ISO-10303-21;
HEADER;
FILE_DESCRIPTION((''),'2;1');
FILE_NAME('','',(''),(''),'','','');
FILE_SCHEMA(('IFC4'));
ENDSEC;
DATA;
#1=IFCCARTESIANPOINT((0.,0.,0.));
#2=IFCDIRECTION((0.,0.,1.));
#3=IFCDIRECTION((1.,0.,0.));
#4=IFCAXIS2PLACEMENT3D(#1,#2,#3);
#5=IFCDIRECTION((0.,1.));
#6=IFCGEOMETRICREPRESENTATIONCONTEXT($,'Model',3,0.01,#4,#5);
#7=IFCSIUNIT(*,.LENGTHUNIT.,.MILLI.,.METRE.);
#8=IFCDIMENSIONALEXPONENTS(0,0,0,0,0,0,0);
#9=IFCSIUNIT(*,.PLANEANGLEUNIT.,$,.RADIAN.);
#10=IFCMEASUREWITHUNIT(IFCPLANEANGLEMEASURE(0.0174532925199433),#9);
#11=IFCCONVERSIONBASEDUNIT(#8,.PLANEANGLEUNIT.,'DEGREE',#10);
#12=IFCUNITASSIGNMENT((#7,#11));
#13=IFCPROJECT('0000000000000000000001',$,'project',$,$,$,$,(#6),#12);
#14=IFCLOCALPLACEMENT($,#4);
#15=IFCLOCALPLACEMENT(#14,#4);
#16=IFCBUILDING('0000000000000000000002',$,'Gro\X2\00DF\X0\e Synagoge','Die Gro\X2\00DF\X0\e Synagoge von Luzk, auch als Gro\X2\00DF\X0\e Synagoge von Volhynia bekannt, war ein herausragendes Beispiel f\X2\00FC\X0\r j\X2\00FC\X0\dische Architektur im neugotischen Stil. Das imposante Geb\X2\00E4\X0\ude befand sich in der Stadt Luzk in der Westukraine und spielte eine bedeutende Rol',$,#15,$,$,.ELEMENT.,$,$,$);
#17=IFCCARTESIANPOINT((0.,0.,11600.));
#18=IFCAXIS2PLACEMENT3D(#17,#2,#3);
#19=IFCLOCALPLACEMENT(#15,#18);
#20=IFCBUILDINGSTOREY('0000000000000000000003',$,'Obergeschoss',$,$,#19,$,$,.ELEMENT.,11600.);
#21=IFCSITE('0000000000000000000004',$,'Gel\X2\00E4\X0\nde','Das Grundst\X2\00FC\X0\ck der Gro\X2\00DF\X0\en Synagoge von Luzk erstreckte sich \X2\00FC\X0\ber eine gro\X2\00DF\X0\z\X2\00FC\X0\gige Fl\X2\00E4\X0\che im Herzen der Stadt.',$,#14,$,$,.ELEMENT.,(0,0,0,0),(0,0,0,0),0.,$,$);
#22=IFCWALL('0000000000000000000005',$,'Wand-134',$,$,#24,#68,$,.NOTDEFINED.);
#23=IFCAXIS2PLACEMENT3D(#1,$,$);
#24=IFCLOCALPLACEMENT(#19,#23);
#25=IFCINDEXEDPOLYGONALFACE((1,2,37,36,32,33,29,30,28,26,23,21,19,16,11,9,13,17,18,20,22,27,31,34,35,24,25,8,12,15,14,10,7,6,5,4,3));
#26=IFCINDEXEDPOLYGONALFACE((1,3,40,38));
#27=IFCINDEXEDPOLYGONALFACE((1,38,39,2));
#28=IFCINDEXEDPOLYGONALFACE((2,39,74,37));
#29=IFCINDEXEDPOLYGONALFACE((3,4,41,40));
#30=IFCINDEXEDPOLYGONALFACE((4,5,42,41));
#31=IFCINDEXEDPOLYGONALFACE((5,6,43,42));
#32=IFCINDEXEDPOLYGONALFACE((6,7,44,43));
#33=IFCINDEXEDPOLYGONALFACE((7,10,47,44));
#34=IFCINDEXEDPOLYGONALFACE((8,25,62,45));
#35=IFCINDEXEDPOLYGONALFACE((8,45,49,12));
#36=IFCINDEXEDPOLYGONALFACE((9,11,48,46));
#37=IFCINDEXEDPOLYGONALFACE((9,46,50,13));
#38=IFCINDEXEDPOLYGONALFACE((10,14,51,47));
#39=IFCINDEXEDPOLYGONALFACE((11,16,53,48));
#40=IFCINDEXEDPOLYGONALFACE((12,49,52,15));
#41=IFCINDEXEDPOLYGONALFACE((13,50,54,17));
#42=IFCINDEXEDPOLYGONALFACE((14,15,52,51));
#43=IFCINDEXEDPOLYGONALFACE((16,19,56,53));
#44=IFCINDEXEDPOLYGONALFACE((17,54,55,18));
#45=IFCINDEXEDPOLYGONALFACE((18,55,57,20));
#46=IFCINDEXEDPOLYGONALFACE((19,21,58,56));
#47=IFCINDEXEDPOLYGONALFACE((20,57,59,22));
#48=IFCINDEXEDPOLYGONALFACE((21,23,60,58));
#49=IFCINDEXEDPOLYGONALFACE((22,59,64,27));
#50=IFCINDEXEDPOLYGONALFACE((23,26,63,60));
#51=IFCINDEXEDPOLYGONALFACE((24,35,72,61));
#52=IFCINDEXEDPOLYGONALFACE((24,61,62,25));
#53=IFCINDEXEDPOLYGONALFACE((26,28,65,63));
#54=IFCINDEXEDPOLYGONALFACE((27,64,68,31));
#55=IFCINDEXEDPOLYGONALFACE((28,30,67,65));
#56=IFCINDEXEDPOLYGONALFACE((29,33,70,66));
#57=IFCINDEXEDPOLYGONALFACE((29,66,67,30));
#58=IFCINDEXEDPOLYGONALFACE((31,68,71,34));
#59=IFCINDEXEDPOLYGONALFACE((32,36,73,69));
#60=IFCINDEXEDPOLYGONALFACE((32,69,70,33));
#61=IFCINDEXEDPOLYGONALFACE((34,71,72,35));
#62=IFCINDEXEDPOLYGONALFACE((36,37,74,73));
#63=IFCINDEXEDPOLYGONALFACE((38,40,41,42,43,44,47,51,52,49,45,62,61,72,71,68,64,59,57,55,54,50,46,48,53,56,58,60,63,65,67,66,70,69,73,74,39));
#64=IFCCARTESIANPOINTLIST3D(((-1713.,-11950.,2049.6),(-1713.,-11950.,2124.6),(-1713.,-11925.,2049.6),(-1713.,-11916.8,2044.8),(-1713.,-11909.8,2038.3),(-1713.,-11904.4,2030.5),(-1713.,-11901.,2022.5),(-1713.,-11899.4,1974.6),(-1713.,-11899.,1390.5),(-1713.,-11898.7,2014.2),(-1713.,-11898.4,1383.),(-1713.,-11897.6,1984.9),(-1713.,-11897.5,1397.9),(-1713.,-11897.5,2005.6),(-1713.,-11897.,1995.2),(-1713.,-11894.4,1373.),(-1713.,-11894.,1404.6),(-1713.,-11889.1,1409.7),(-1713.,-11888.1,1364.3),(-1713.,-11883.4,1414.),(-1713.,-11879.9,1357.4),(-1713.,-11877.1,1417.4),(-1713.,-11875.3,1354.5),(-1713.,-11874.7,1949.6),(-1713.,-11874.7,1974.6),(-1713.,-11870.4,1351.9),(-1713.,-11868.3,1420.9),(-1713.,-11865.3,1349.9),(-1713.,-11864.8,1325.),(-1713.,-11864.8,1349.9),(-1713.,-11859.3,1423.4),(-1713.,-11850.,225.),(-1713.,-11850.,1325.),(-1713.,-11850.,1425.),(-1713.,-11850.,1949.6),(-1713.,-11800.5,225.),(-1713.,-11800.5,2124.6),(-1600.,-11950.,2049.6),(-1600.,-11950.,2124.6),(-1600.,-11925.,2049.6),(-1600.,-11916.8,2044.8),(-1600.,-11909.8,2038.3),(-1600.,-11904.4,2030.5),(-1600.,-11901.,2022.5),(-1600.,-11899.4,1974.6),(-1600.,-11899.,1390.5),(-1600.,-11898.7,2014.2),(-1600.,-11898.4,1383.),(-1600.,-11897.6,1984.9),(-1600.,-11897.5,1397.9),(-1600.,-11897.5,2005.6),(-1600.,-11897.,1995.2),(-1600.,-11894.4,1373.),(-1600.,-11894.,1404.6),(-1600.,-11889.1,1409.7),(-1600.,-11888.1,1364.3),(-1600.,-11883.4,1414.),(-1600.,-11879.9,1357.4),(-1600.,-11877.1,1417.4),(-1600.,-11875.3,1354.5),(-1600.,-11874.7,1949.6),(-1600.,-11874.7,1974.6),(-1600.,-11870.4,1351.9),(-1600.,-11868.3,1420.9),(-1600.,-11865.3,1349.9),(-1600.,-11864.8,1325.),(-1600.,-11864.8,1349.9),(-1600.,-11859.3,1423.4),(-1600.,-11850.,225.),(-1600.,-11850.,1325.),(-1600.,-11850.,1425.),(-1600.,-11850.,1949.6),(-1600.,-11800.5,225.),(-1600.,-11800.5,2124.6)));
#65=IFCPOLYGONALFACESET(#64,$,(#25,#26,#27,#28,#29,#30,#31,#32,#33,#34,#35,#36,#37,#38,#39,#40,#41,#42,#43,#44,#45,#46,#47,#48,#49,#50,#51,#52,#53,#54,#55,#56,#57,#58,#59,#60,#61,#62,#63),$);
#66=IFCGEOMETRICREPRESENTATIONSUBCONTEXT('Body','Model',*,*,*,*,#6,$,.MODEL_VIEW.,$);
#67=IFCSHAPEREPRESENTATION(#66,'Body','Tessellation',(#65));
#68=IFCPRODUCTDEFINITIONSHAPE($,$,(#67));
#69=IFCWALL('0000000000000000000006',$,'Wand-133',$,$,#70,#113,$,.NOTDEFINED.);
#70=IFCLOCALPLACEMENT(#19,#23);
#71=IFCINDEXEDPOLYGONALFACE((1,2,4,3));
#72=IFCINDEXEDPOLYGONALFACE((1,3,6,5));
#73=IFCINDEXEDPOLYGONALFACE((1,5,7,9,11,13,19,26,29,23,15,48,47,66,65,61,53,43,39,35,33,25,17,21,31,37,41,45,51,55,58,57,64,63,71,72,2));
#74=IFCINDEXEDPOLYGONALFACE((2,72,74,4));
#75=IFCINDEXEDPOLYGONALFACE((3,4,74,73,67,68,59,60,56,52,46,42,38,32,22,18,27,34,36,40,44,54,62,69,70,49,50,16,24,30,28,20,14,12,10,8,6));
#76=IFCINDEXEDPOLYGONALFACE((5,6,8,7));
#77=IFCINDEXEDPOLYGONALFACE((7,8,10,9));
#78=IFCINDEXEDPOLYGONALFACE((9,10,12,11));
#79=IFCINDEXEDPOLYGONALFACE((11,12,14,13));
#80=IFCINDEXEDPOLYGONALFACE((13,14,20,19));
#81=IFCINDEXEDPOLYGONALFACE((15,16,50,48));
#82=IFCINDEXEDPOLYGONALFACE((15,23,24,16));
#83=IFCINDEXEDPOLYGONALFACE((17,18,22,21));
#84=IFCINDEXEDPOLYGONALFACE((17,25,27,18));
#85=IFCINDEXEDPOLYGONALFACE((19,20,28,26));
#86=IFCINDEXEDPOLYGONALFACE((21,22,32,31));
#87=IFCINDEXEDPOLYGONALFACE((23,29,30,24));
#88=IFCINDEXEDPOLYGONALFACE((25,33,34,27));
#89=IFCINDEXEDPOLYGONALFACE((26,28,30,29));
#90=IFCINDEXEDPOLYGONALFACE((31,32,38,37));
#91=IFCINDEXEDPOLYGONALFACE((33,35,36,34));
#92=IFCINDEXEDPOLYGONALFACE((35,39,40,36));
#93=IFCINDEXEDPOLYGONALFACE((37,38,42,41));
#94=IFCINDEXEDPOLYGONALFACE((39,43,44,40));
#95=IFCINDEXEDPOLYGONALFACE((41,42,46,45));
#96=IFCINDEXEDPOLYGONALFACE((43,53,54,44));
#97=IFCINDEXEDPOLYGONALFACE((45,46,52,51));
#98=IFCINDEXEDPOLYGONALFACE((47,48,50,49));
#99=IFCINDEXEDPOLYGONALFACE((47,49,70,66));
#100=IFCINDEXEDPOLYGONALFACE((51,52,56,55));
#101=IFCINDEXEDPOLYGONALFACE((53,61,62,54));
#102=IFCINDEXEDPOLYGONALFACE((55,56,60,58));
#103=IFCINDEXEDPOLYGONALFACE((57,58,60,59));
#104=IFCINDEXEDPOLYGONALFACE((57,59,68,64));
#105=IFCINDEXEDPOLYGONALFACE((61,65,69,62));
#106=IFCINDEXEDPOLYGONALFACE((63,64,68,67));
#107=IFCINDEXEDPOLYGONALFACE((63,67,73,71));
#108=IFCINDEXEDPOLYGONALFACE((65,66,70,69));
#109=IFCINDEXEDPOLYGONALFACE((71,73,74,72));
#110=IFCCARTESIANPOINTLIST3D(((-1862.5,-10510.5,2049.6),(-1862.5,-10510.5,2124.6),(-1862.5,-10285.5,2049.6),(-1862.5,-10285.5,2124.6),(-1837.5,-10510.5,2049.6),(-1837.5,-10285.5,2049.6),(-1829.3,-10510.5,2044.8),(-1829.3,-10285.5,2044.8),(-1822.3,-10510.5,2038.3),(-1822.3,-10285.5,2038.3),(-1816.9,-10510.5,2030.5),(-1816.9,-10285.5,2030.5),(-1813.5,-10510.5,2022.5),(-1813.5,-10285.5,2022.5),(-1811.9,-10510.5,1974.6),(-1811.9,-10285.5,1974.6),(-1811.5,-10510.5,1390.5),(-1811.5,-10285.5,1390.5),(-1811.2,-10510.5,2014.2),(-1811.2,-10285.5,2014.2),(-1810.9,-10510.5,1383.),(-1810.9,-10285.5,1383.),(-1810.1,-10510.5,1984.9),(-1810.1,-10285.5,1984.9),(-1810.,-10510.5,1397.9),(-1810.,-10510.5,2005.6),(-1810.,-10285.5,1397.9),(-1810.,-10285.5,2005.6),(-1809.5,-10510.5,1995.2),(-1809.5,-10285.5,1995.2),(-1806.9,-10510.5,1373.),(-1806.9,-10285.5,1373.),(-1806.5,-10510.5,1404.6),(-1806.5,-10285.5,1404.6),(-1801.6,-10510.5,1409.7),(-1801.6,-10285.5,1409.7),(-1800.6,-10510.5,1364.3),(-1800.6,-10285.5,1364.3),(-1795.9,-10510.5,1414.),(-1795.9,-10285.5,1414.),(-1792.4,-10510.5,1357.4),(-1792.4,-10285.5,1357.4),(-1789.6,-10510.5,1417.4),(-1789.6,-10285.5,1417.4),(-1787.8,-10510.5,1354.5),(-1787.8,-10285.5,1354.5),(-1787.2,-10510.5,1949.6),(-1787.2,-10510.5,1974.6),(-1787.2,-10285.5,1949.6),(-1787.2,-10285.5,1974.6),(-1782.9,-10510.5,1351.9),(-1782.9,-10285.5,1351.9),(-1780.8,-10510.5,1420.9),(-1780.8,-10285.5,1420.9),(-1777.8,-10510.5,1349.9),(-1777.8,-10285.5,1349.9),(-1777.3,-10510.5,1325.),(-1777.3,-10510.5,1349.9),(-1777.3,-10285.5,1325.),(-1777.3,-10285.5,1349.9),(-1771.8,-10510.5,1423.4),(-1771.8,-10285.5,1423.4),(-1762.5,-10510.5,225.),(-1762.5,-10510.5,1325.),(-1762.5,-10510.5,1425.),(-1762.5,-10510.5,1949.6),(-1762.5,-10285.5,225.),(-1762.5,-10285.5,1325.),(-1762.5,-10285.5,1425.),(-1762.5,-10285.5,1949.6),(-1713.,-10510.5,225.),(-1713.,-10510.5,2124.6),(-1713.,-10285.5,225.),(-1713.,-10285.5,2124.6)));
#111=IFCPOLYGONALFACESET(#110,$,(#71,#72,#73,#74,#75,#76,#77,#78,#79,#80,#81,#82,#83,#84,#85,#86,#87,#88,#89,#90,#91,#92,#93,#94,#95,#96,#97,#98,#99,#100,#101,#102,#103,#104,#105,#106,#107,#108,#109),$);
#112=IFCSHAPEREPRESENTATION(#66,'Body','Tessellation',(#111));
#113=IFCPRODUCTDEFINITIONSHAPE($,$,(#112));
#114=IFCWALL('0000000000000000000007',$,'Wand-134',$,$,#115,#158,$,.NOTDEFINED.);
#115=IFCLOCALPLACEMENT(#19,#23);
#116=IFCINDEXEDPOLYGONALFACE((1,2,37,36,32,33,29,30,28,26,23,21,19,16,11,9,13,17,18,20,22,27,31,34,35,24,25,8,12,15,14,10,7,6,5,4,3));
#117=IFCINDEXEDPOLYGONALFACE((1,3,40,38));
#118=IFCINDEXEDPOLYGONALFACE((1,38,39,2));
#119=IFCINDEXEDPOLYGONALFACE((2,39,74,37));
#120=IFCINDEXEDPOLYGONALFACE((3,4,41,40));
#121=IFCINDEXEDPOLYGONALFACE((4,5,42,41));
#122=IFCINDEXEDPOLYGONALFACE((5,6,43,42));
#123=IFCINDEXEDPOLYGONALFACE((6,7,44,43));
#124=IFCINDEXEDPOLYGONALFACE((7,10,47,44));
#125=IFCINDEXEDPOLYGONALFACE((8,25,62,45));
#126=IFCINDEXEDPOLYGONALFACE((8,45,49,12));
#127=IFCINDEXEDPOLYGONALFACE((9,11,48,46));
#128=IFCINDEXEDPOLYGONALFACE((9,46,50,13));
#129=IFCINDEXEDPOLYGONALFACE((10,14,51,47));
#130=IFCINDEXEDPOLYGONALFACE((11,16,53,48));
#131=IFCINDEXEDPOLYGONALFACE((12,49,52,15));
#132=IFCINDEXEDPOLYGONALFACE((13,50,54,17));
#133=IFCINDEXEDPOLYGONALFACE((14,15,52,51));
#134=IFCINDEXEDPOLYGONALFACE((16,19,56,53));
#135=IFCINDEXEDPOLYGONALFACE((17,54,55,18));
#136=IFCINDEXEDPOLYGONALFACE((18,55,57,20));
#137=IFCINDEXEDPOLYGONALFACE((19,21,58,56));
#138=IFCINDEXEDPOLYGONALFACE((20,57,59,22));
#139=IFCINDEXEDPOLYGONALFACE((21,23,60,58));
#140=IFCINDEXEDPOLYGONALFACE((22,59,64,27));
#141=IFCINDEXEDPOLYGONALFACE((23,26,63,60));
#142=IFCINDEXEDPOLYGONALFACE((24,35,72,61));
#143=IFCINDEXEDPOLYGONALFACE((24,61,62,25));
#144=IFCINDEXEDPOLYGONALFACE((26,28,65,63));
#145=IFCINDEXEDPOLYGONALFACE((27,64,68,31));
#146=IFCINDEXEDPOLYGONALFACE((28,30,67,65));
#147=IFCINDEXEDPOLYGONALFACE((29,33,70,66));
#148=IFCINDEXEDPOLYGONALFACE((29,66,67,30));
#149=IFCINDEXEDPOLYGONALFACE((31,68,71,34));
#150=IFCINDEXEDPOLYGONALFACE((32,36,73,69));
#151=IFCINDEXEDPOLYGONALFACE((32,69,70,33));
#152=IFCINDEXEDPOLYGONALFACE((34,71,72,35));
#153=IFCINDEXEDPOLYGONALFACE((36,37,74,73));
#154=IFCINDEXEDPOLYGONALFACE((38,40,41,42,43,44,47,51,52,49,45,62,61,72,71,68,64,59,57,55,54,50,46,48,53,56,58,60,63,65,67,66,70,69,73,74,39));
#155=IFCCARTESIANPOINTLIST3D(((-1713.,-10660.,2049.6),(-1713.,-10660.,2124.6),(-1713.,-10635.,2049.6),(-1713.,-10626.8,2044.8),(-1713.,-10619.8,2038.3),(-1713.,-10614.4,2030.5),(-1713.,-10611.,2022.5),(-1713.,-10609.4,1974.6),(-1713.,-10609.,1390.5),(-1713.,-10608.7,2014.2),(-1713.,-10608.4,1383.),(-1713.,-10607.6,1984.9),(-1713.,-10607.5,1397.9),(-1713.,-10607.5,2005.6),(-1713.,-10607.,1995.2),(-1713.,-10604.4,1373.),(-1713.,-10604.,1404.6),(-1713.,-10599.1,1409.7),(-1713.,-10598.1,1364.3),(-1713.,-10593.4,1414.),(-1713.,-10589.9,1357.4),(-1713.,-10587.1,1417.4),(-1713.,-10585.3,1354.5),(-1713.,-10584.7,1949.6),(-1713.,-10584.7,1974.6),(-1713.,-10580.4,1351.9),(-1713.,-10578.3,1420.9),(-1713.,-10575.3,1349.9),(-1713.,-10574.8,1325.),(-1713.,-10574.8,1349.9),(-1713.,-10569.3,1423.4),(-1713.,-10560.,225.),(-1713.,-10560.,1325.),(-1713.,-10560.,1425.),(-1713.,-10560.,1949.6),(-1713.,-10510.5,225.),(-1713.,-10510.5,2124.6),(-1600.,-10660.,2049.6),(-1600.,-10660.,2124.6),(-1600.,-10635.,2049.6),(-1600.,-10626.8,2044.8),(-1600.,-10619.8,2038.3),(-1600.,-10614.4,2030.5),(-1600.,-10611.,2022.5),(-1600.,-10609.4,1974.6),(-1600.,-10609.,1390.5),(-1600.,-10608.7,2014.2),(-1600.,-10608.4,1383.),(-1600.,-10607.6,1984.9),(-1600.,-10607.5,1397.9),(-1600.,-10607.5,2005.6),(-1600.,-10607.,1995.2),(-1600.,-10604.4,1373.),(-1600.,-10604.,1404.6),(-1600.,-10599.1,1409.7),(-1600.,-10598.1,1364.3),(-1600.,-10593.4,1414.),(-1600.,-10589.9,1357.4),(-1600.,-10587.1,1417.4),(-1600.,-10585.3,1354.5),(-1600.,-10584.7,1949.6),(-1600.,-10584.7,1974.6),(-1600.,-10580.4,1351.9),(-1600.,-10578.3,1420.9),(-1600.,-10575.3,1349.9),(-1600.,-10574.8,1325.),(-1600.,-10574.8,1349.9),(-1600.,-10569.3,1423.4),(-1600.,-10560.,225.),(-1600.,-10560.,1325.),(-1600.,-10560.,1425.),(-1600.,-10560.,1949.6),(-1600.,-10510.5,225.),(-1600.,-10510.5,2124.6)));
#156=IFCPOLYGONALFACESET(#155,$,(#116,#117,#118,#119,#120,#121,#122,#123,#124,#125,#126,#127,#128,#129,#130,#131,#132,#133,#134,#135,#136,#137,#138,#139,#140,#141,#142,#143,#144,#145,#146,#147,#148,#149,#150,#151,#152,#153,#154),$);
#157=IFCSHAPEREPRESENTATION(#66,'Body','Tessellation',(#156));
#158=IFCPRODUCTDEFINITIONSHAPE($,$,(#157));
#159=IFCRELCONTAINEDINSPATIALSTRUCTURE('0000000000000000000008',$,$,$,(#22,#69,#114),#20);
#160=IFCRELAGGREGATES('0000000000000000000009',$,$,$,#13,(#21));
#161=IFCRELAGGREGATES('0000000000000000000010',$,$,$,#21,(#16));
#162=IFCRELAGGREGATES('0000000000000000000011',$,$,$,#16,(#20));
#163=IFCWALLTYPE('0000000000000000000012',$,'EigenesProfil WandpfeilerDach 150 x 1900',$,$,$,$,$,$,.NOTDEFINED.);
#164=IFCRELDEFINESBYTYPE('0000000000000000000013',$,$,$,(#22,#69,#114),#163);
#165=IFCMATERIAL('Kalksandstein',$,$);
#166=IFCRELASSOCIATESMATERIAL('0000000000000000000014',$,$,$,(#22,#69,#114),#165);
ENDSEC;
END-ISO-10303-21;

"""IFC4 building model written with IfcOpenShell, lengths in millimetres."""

from ifc_helpers import new_model, entity, si_unit, converted_unit, direction, frame, origin_with_axes, place, context, subcontext, project, spatial, line, arc, indexed_curve, outline, extrude, material, material_profile, profile_set, type_object, element, save


model = new_model("IFC4")

# Units and contexts
model_context = context("Model", 3, precision=0.01, world=origin_with_axes(), true_north=direction((0.0, 1.0)))
body_context = subcontext(model_context, "Body", "Model", "MODEL_VIEW")
ifc_project = project(units=[si_unit("LENGTHUNIT", "METRE", prefix="MILLI"), converted_unit("PLANEANGLEUNIT", "DEGREE", entity("IfcPlaneAngleMeasure", 0.0174532925199433), si_unit("PLANEANGLEUNIT", "RADIAN"), dimensions=[0, 0, 0, 0, 0, 0, 0])], contexts=[model_context])

# Site, building, storey
site_placement = place(None, origin_with_axes())
site = spatial("IfcSite", under=ifc_project, at=site_placement, Name="Gelände", Description="Das Grundstück der Großen Synagoge von Luzk erstreckte sich über eine großzügige Fläche im Herzen der Stadt.", CompositionType="ELEMENT", RefLatitude=(0, 0, 0, 0), RefLongitude=(0, 0, 0, 0), RefElevation=0.0)
building_placement = place(site_placement, origin_with_axes())
building = spatial("IfcBuilding", under=site, at=building_placement, Name="Große Synagoge", Description="Die Große Synagoge von Luzk, auch als Große Synagoge von Volhynia bekannt, war ein herausragendes Beispiel für jüdische Architektur im neugotischen Stil. Das imposante Gebäude befand sich in der Stadt Luzk in der Westukraine und spielte eine bedeutende Rol", CompositionType="ELEMENT")
storey_placement = place(building_placement, frame((0.0, 0.0, 11600.0), z_axis=(0.0, 0.0, 1.0), x_axis=(1.0, 0.0, 0.0)))
storey = spatial("IfcBuildingStorey", under=building, at=storey_placement, Name="Obergeschoss", CompositionType="ELEMENT", Elevation=11600.0)

# Walls
ifc_material_1 = material(Name="Kalksandstein")
ifc_material_profile = material_profile(ifc_material_1, outline(indexed_curve([(74.2, 1749.6), (98.9, 1749.6), (96.7, 1765.0), (97.0, 1780.5), (99.2, 1793.4), (103.9, 1805.5), (112.6, 1816.7), (124.5, 1824.6), (149.5, 1824.6), (149.5, 1899.6), (0.0, 1899.6), (0.0, 0.0), (49.5, 0.0), (49.5, 1100.0), (64.3, 1100.0), (64.3, 1124.9), (64.8, 1124.9), (72.4, 1128.1), (79.4, 1132.4), (91.1, 1143.4), (97.9, 1157.9), (98.0, 1169.2), (93.5, 1179.5), (85.8, 1187.0), (76.6, 1192.3), (63.3, 1197.2), (49.5, 1200.0), (49.5, 1724.6), (74.2, 1724.6)], segments=[line(1, 2), arc(2, 3, 4), arc(4, 5, 6), arc(6, 7, 8), line(8, 9, 10, 11, 12, 13, 14, 15, 16, 17), arc(17, 18, 19), arc(19, 20, 21), arc(21, 22, 23), arc(23, 24, 25), arc(25, 26, 27), line(27, 28, 29, 1)])), Name="Kalksandstein")
ifc_profile_set = profile_set([ifc_material_profile], Name="EigenesProfil WandpfeilerDach")
wall_type_1 = type_object("IfcWallType", Name="EigenesProfil WandpfeilerDach 150 x 1900", PredefinedType="NOTDEFINED")
wall_1_placement = place(storey_placement, frame((-1713.0, -11800.5, 225.0), z_axis=(0.0, 0.0, 1.0), x_axis=(1.0, 0.0, 0.0)))
element("IfcWall", 1, at=wall_1_placement, inside=storey, type_object=wall_type_1, material=ifc_profile_set, Name="Wand-134", PredefinedType="NOTDEFINED", context=body_context, shape_type="SweptSolid", body=[
    extrude(outline(indexed_curve([(74.2, 1749.6), (98.9, 1749.6), (96.7, 1765.0), (97.0, 1780.5), (99.2, 1793.4), (103.9, 1805.5), (112.6, 1816.7), (124.5, 1824.6), (149.5, 1824.6), (149.5, 1899.6), (0.0, 1899.6), (0.0, 0.0), (49.5, 0.0), (49.5, 1100.0), (64.3, 1100.0), (64.3, 1124.9), (64.8, 1124.9), (72.4, 1128.1), (79.4, 1132.4), (91.1, 1143.4), (97.9, 1157.9), (98.0, 1169.2), (93.5, 1179.5), (85.8, 1187.0), (76.6, 1192.3), (63.3, 1197.2), (49.5, 1200.0), (49.5, 1724.6), (74.2, 1724.6)], segments=[line(1, 2), arc(2, 3, 4), arc(4, 5, 6), arc(6, 7, 8), line(8, 9, 10, 11, 12, 13, 14, 15, 16, 17), arc(17, 18, 19), arc(19, 20, 21), arc(21, 22, 23), arc(23, 24, 25), arc(25, 26, 27), line(27, 28, 29, 1)])), frame((0.0, 0.0, 0.0), z_axis=(-1.0, 0.0, 0.0), x_axis=(0.0, -1.0, 0.0)), (0.0, 0.0, -1.0), 113.0),
])
wall_2_placement = place(storey_placement, frame((-1713.0, -10285.5, 225.0), z_axis=(0.0, 0.0, 1.0), x_axis=(0.0, -1.0, 0.0)))
element("IfcWall", 2, at=wall_2_placement, inside=storey, type_object=wall_type_1, material=ifc_profile_set, Name="Wand-133", PredefinedType="NOTDEFINED", context=body_context, shape_type="SweptSolid", body=[
    extrude(outline(indexed_curve([(74.2, 1749.6), (98.9, 1749.6), (96.7, 1765.0), (97.0, 1780.5), (99.2, 1793.4), (103.9, 1805.5), (112.6, 1816.7), (124.5, 1824.6), (149.5, 1824.6), (149.5, 1899.6), (0.0, 1899.6), (0.0, 0.0), (49.5, 0.0), (49.5, 1100.0), (64.3, 1100.0), (64.3, 1124.9), (64.8, 1124.9), (72.4, 1128.1), (79.4, 1132.4), (91.1, 1143.4), (97.9, 1157.9), (98.0, 1169.2), (93.5, 1179.5), (85.8, 1187.0), (76.6, 1192.3), (63.3, 1197.2), (49.5, 1200.0), (49.5, 1724.6), (74.2, 1724.6)], segments=[line(1, 2), arc(2, 3, 4), arc(4, 5, 6), arc(6, 7, 8), line(8, 9, 10, 11, 12, 13, 14, 15, 16, 17), arc(17, 18, 19), arc(19, 20, 21), arc(21, 22, 23), arc(23, 24, 25), arc(25, 26, 27), line(27, 28, 29, 1)])), frame((0.0, 0.0, 0.0), z_axis=(-1.0, 0.0, 0.0), x_axis=(0.0, -1.0, 0.0)), (0.0, 0.0, -1.0), 225.0),
])
wall_3_placement = place(storey_placement, frame((-1713.0, -10510.5, 225.0), z_axis=(0.0, 0.0, 1.0), x_axis=(1.0, 0.0, 0.0)))
element("IfcWall", 3, at=wall_3_placement, inside=storey, type_object=wall_type_1, material=ifc_profile_set, Name="Wand-134", PredefinedType="NOTDEFINED", context=body_context, shape_type="SweptSolid", body=[
    extrude(outline(indexed_curve([(74.2, 1749.6), (98.9, 1749.6), (96.7, 1765.0), (97.0, 1780.5), (99.2, 1793.4), (103.9, 1805.5), (112.6, 1816.7), (124.5, 1824.6), (149.5, 1824.6), (149.5, 1899.6), (0.0, 1899.6), (0.0, 0.0), (49.5, 0.0), (49.5, 1100.0), (64.3, 1100.0), (64.3, 1124.9), (64.8, 1124.9), (72.4, 1128.1), (79.4, 1132.4), (91.1, 1143.4), (97.9, 1157.9), (98.0, 1169.2), (93.5, 1179.5), (85.8, 1187.0), (76.6, 1192.3), (63.3, 1197.2), (49.5, 1200.0), (49.5, 1724.6), (74.2, 1724.6)], segments=[line(1, 2), arc(2, 3, 4), arc(4, 5, 6), arc(6, 7, 8), line(8, 9, 10, 11, 12, 13, 14, 15, 16, 17), arc(17, 18, 19), arc(19, 20, 21), arc(21, 22, 23), arc(23, 24, 25), arc(25, 26, 27), line(27, 28, 29, 1)])), frame((0.0, 0.0, 0.0), z_axis=(-1.0, 0.0, 0.0), x_axis=(0.0, -1.0, 0.0)), (0.0, 0.0, -1.0), 113.0),
])

save(model, "model.ifc")
